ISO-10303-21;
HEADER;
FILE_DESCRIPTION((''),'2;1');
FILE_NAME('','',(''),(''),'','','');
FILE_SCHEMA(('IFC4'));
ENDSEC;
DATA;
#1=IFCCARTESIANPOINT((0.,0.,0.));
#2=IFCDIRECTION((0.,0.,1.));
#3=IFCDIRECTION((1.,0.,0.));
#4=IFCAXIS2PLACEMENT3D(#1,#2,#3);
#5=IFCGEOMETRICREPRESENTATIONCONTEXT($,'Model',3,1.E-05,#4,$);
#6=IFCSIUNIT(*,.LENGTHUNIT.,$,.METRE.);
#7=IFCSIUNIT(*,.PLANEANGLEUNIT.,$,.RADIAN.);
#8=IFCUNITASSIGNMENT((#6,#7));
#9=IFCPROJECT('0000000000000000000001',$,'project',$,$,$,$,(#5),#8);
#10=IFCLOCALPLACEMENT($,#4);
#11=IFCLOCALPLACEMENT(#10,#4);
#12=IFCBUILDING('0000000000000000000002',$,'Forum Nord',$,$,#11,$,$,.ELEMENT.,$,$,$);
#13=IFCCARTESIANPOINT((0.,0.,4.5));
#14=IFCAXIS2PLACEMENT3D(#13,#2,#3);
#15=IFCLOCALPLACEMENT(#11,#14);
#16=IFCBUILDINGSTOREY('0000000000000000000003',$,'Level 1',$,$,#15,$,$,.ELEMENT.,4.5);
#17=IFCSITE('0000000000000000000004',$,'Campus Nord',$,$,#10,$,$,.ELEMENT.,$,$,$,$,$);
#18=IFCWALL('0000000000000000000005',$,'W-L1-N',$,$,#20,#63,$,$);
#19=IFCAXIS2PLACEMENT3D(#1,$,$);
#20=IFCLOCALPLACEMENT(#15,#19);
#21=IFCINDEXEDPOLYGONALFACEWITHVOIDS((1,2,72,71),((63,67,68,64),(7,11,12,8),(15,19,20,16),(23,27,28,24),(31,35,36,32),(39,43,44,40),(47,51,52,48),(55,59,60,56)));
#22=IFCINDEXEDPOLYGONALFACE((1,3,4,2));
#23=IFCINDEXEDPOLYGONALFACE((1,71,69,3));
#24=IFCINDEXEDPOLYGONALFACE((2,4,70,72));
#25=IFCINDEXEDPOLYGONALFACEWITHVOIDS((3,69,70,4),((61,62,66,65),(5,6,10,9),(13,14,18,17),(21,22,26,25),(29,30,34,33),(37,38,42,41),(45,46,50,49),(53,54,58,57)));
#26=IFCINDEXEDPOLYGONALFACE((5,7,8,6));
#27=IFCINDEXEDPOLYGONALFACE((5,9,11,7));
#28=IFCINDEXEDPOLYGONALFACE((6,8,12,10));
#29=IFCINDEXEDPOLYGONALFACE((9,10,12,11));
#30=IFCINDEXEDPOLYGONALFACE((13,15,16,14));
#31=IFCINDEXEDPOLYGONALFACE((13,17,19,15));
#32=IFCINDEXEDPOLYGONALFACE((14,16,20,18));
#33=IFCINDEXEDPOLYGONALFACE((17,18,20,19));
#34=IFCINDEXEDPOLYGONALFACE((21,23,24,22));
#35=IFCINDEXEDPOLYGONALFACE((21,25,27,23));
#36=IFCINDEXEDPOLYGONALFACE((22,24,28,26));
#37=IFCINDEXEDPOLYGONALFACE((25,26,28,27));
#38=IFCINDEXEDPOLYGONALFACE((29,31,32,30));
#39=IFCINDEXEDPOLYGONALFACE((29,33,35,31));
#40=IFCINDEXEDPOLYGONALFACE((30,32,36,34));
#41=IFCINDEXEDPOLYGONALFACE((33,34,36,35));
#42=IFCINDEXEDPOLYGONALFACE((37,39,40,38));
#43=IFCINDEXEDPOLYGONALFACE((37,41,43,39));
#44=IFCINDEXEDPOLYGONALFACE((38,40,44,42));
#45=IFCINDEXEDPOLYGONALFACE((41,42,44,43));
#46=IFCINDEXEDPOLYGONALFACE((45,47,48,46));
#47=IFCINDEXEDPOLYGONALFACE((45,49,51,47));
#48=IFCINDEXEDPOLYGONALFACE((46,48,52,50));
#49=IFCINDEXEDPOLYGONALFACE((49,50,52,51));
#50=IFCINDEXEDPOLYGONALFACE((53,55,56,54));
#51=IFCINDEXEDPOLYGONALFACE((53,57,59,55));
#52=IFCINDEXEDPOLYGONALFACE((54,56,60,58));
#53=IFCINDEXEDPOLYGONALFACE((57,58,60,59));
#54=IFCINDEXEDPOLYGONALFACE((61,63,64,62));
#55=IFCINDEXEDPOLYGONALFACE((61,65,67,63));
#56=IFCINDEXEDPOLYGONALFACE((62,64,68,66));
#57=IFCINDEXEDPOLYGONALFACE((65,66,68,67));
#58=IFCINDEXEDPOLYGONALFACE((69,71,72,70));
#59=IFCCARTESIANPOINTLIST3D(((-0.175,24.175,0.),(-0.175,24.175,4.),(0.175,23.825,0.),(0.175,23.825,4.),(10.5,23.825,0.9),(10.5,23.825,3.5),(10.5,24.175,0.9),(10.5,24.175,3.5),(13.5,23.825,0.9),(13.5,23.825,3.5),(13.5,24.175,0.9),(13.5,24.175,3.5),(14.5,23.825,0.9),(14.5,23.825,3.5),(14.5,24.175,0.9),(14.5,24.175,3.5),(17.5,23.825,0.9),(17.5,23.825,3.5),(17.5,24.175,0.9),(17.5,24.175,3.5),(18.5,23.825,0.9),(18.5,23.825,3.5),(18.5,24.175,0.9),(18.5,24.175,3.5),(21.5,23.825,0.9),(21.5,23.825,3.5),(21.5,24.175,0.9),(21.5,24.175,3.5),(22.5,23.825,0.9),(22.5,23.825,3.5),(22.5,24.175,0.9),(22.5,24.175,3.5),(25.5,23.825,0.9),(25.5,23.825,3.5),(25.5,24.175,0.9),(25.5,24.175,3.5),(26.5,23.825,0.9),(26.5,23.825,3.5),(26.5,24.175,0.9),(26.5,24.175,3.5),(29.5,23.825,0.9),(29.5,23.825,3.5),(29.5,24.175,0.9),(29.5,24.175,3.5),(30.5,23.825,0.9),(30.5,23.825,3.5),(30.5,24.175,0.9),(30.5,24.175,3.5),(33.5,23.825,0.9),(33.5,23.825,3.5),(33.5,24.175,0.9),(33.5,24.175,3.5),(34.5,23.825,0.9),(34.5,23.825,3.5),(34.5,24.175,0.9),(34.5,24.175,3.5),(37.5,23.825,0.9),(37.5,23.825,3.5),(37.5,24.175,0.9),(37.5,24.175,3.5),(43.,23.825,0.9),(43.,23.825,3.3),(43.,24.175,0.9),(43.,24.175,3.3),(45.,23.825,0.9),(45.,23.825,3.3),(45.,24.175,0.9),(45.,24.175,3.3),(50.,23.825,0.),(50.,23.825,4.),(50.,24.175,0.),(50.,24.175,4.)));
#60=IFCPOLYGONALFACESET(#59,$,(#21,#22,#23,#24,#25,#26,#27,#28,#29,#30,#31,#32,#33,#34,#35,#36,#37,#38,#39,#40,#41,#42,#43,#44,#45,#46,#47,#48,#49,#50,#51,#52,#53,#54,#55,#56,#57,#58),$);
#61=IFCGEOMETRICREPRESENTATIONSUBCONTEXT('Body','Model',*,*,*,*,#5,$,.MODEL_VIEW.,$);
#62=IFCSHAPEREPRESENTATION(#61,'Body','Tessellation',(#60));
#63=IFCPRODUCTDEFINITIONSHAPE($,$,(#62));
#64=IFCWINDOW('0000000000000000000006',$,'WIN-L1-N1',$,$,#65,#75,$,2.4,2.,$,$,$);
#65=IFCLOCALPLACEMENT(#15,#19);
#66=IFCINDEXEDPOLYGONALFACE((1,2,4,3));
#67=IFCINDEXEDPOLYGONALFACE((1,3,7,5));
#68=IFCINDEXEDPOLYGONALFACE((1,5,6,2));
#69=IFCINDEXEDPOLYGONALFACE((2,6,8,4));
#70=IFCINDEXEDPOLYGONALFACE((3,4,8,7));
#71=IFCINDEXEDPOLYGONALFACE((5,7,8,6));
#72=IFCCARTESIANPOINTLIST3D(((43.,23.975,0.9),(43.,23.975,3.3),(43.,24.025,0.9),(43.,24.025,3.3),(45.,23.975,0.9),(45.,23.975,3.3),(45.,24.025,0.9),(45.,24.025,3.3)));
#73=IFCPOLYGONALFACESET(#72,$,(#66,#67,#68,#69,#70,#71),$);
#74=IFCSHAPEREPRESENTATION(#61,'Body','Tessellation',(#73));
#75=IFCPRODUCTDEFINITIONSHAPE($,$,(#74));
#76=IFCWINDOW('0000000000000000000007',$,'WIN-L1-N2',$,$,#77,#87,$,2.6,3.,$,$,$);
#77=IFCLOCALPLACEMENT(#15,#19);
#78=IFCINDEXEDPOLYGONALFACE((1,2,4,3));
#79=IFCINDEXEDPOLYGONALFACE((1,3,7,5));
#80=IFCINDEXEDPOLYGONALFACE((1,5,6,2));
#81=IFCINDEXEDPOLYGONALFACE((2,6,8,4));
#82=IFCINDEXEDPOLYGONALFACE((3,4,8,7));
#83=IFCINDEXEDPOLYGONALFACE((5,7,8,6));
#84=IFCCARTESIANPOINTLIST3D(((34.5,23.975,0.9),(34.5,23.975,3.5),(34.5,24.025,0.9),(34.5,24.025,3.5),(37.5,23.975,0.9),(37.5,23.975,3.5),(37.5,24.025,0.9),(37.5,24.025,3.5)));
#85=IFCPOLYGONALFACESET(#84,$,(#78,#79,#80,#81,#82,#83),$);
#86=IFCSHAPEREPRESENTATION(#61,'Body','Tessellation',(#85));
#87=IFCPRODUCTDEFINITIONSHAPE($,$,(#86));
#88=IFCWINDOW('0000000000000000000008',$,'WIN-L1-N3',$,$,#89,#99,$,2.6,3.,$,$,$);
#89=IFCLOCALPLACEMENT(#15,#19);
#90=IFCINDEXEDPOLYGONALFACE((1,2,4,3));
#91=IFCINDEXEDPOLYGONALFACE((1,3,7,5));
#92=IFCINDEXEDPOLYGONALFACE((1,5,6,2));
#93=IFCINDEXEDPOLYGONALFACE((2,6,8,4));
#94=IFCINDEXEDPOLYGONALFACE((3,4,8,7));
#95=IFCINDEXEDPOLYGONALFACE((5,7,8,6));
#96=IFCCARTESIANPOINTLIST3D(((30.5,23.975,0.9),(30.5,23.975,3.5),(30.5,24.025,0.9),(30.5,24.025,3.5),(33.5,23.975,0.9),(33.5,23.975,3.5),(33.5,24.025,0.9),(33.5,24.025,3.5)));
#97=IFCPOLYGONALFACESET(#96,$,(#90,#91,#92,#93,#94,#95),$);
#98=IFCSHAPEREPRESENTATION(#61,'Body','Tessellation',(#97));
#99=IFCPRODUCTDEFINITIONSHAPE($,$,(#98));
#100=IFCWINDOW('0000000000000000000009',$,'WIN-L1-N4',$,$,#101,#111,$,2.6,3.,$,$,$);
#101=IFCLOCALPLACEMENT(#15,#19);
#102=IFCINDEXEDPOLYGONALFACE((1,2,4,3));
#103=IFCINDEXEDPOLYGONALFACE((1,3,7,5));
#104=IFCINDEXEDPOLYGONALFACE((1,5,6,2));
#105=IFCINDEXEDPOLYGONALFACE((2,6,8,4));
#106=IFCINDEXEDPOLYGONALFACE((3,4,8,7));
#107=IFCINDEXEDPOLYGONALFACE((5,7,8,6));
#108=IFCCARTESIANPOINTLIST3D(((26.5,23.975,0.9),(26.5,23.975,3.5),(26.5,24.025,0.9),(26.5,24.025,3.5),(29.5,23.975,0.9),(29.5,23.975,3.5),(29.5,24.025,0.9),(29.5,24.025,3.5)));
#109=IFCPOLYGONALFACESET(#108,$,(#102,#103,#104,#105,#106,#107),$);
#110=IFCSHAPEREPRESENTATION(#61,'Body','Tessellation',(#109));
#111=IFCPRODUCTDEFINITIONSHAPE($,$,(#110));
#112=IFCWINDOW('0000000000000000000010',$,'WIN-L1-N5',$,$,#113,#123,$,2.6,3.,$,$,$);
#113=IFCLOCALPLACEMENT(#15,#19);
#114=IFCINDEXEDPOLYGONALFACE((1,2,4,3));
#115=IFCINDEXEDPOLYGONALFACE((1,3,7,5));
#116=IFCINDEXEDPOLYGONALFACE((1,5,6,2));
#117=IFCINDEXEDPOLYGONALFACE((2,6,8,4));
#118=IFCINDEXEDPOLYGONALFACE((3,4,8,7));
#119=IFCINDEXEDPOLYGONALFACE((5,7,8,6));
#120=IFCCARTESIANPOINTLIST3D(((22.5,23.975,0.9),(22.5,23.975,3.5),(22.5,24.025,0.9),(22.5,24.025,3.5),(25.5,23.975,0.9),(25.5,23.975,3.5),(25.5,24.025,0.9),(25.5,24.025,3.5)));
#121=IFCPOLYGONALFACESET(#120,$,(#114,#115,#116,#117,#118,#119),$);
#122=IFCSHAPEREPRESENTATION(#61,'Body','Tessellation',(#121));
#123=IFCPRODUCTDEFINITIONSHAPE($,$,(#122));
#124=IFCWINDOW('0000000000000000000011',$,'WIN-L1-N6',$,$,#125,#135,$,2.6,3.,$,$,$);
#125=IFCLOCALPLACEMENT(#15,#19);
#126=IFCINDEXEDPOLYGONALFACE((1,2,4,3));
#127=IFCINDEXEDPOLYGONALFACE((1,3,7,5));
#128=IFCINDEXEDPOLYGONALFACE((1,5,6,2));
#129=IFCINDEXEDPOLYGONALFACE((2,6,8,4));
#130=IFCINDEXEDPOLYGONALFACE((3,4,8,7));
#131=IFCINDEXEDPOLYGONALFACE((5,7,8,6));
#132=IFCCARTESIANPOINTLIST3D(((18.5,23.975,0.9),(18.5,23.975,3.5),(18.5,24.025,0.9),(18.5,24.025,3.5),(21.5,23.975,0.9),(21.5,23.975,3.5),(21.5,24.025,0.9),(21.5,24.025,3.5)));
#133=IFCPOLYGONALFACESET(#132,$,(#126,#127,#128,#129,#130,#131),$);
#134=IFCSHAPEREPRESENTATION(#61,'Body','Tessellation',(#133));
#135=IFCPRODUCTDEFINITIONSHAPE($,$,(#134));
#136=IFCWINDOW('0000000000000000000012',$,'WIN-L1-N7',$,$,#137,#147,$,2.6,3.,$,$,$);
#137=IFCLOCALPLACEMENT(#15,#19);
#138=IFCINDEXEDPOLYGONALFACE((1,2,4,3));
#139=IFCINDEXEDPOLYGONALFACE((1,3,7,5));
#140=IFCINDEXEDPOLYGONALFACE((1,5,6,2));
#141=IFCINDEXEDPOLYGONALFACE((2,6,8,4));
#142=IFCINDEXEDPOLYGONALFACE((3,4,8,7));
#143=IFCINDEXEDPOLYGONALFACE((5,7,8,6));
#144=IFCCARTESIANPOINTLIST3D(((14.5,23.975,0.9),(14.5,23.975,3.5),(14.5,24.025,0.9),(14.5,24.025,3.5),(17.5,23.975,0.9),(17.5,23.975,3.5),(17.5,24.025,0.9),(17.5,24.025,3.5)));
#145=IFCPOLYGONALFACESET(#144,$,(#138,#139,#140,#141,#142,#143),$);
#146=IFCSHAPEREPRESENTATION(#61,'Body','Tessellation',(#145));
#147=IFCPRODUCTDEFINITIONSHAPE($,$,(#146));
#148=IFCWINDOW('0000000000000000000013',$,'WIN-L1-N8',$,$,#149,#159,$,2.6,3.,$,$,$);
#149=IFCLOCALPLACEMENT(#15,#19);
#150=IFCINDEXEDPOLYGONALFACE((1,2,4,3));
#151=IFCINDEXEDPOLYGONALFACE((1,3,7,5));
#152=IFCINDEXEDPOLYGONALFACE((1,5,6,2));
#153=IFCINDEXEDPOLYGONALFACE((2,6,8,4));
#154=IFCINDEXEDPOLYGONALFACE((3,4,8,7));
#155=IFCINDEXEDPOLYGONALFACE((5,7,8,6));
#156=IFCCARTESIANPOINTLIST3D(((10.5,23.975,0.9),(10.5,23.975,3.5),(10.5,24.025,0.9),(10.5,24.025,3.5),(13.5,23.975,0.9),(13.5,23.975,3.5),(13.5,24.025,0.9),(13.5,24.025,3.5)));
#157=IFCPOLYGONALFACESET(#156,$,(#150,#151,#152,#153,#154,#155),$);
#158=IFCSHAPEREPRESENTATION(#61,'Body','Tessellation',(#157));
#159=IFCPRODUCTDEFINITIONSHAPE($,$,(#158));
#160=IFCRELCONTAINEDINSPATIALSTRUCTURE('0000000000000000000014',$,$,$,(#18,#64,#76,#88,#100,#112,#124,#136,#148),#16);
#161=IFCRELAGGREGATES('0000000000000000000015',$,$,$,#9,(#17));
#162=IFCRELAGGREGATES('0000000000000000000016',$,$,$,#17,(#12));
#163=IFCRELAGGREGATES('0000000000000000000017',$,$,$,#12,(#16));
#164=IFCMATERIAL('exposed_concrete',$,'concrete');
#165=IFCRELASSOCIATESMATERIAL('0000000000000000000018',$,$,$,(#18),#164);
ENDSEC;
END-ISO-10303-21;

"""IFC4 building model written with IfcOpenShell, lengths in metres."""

from ifc_helpers import new_model, si_unit, frame, frame_2d, origin_with_axes, place, context, subcontext, project, spatial, polyline, rectangle, outline, extrude, material, element, fill, save


model = new_model("IFC4")

# Units and contexts
model_context = context("Model", 3, precision=1e-05, world=origin_with_axes())
body_context = subcontext(model_context, "Body", "Model", "MODEL_VIEW")
ifc_project = project(units=[si_unit("LENGTHUNIT", "METRE"), si_unit("PLANEANGLEUNIT", "RADIAN")], contexts=[model_context])

# Site, building, storey
site_placement = place(None, origin_with_axes())
site = spatial("IfcSite", under=ifc_project, at=site_placement, Name="Campus Nord", CompositionType="ELEMENT")
building_placement = place(site_placement, origin_with_axes())
building = spatial("IfcBuilding", under=site, at=building_placement, Name="Forum Nord", CompositionType="ELEMENT")
storey_placement = place(building_placement, frame((0.0, 0.0, 4.5), z_axis=(0.0, 0.0, 1.0), x_axis=(1.0, 0.0, 0.0)))
storey = spatial("IfcBuildingStorey", under=building, at=storey_placement, Name="Level 1", CompositionType="ELEMENT", Elevation=4.5)

# Wall, openings, windows
ifc_material_1 = material(Name="exposed_concrete", Category="concrete")
wall_1_placement = place(storey_placement, frame((50.0, 24.0, 0.0), z_axis=(0.0, 0.0, 1.0), x_axis=(-1.0, 0.0, 0.0)))
wall_1 = element("IfcWall", 1, at=wall_1_placement, inside=storey, material=ifc_material_1, Name="W-L1-N", context=body_context, shape_type="SweptSolid", body=[
    extrude(outline(polyline([(0.0, -0.175), (50.175, -0.175), (49.825, 0.175), (0.0, 0.175), (0.0, -0.175)])), origin_with_axes(), (0.0, 0.0, 1.0), 4.0),
])
opening_1_placement = place(storey_placement, frame((50.0, 24.0, 0.0), z_axis=(0.0, 0.0, 1.0), x_axis=(-1.0, 0.0, 0.0)))
opening_1 = element("IfcOpeningElement", 2, at=opening_1_placement, cuts=wall_1, context=body_context, shape_type="SweptSolid", body=[
    extrude(rectangle(XDim=2.0, YDim=0.35, at=frame_2d((6.0, 0.0), x_axis=(1.0, 0.0))), frame((0.0, 0.0, 0.9), z_axis=(0.0, 0.0, 1.0), x_axis=(1.0, 0.0, 0.0)), (0.0, 0.0, 1.0), 2.4),
])
opening_2_placement = place(storey_placement, frame((50.0, 24.0, 0.0), z_axis=(0.0, 0.0, 1.0), x_axis=(-1.0, 0.0, 0.0)))
opening_2 = element("IfcOpeningElement", 3, at=opening_2_placement, cuts=wall_1, context=body_context, shape_type="SweptSolid", body=[
    extrude(rectangle(XDim=3.0, YDim=0.35, at=frame_2d((14.0, 0.0), x_axis=(1.0, 0.0))), frame((0.0, 0.0, 0.9), z_axis=(0.0, 0.0, 1.0), x_axis=(1.0, 0.0, 0.0)), (0.0, 0.0, 1.0), 2.6),
])
opening_3_placement = place(storey_placement, frame((50.0, 24.0, 0.0), z_axis=(0.0, 0.0, 1.0), x_axis=(-1.0, 0.0, 0.0)))
opening_3 = element("IfcOpeningElement", 4, at=opening_3_placement, cuts=wall_1, context=body_context, shape_type="SweptSolid", body=[
    extrude(rectangle(XDim=3.0, YDim=0.35, at=frame_2d((18.0, 0.0), x_axis=(1.0, 0.0))), frame((0.0, 0.0, 0.9), z_axis=(0.0, 0.0, 1.0), x_axis=(1.0, 0.0, 0.0)), (0.0, 0.0, 1.0), 2.6),
])
opening_4_placement = place(storey_placement, frame((50.0, 24.0, 0.0), z_axis=(0.0, 0.0, 1.0), x_axis=(-1.0, 0.0, 0.0)))
opening_4 = element("IfcOpeningElement", 5, at=opening_4_placement, cuts=wall_1, context=body_context, shape_type="SweptSolid", body=[
    extrude(rectangle(XDim=3.0, YDim=0.35, at=frame_2d((22.0, 0.0), x_axis=(1.0, 0.0))), frame((0.0, 0.0, 0.9), z_axis=(0.0, 0.0, 1.0), x_axis=(1.0, 0.0, 0.0)), (0.0, 0.0, 1.0), 2.6),
])
opening_5_placement = place(storey_placement, frame((50.0, 24.0, 0.0), z_axis=(0.0, 0.0, 1.0), x_axis=(-1.0, 0.0, 0.0)))
opening_5 = element("IfcOpeningElement", 6, at=opening_5_placement, cuts=wall_1, context=body_context, shape_type="SweptSolid", body=[
    extrude(rectangle(XDim=3.0, YDim=0.35, at=frame_2d((26.0, 0.0), x_axis=(1.0, 0.0))), frame((0.0, 0.0, 0.9), z_axis=(0.0, 0.0, 1.0), x_axis=(1.0, 0.0, 0.0)), (0.0, 0.0, 1.0), 2.6),
])
opening_6_placement = place(storey_placement, frame((50.0, 24.0, 0.0), z_axis=(0.0, 0.0, 1.0), x_axis=(-1.0, 0.0, 0.0)))
opening_6 = element("IfcOpeningElement", 7, at=opening_6_placement, cuts=wall_1, context=body_context, shape_type="SweptSolid", body=[
    extrude(rectangle(XDim=3.0, YDim=0.35, at=frame_2d((30.0, 0.0), x_axis=(1.0, 0.0))), frame((0.0, 0.0, 0.9), z_axis=(0.0, 0.0, 1.0), x_axis=(1.0, 0.0, 0.0)), (0.0, 0.0, 1.0), 2.6),
])
opening_7_placement = place(storey_placement, frame((50.0, 24.0, 0.0), z_axis=(0.0, 0.0, 1.0), x_axis=(-1.0, 0.0, 0.0)))
opening_7 = element("IfcOpeningElement", 8, at=opening_7_placement, cuts=wall_1, context=body_context, shape_type="SweptSolid", body=[
    extrude(rectangle(XDim=3.0, YDim=0.35, at=frame_2d((34.0, 0.0), x_axis=(1.0, 0.0))), frame((0.0, 0.0, 0.9), z_axis=(0.0, 0.0, 1.0), x_axis=(1.0, 0.0, 0.0)), (0.0, 0.0, 1.0), 2.6),
])
opening_8_placement = place(storey_placement, frame((50.0, 24.0, 0.0), z_axis=(0.0, 0.0, 1.0), x_axis=(-1.0, 0.0, 0.0)))
opening_8 = element("IfcOpeningElement", 9, at=opening_8_placement, cuts=wall_1, context=body_context, shape_type="SweptSolid", body=[
    extrude(rectangle(XDim=3.0, YDim=0.35, at=frame_2d((38.0, 0.0), x_axis=(1.0, 0.0))), frame((0.0, 0.0, 0.9), z_axis=(0.0, 0.0, 1.0), x_axis=(1.0, 0.0, 0.0)), (0.0, 0.0, 1.0), 2.6),
])
window_1_placement = place(storey_placement, frame((50.0, 24.0, 0.0), z_axis=(0.0, 0.0, 1.0), x_axis=(-1.0, 0.0, 0.0)))
window_1 = element("IfcWindow", 10, at=window_1_placement, inside=storey, Name="WIN-L1-N1", OverallHeight=2.4, OverallWidth=2.0, context=body_context, shape_type="SweptSolid", body=[
    extrude(rectangle(XDim=2.0, YDim=0.05, at=frame_2d((6.0, 0.0), x_axis=(1.0, 0.0))), frame((0.0, 0.0, 0.9), z_axis=(0.0, 0.0, 1.0), x_axis=(1.0, 0.0, 0.0)), (0.0, 0.0, 1.0), 2.4),
])
fill(opening_1, window_1)
window_2_placement = place(storey_placement, frame((50.0, 24.0, 0.0), z_axis=(0.0, 0.0, 1.0), x_axis=(-1.0, 0.0, 0.0)))
window_2 = element("IfcWindow", 11, at=window_2_placement, inside=storey, Name="WIN-L1-N2", OverallHeight=2.6, OverallWidth=3.0, context=body_context, shape_type="SweptSolid", body=[
    extrude(rectangle(XDim=3.0, YDim=0.05, at=frame_2d((14.0, 0.0), x_axis=(1.0, 0.0))), frame((0.0, 0.0, 0.9), z_axis=(0.0, 0.0, 1.0), x_axis=(1.0, 0.0, 0.0)), (0.0, 0.0, 1.0), 2.6),
])
fill(opening_2, window_2)
window_3_placement = place(storey_placement, frame((50.0, 24.0, 0.0), z_axis=(0.0, 0.0, 1.0), x_axis=(-1.0, 0.0, 0.0)))
window_3 = element("IfcWindow", 12, at=window_3_placement, inside=storey, Name="WIN-L1-N3", OverallHeight=2.6, OverallWidth=3.0, context=body_context, shape_type="SweptSolid", body=[
    extrude(rectangle(XDim=3.0, YDim=0.05, at=frame_2d((18.0, 0.0), x_axis=(1.0, 0.0))), frame((0.0, 0.0, 0.9), z_axis=(0.0, 0.0, 1.0), x_axis=(1.0, 0.0, 0.0)), (0.0, 0.0, 1.0), 2.6),
])
fill(opening_3, window_3)
window_4_placement = place(storey_placement, frame((50.0, 24.0, 0.0), z_axis=(0.0, 0.0, 1.0), x_axis=(-1.0, 0.0, 0.0)))
window_4 = element("IfcWindow", 13, at=window_4_placement, inside=storey, Name="WIN-L1-N4", OverallHeight=2.6, OverallWidth=3.0, context=body_context, shape_type="SweptSolid", body=[
    extrude(rectangle(XDim=3.0, YDim=0.05, at=frame_2d((22.0, 0.0), x_axis=(1.0, 0.0))), frame((0.0, 0.0, 0.9), z_axis=(0.0, 0.0, 1.0), x_axis=(1.0, 0.0, 0.0)), (0.0, 0.0, 1.0), 2.6),
])
fill(opening_4, window_4)
window_5_placement = place(storey_placement, frame((50.0, 24.0, 0.0), z_axis=(0.0, 0.0, 1.0), x_axis=(-1.0, 0.0, 0.0)))
window_5 = element("IfcWindow", 14, at=window_5_placement, inside=storey, Name="WIN-L1-N5", OverallHeight=2.6, OverallWidth=3.0, context=body_context, shape_type="SweptSolid", body=[
    extrude(rectangle(XDim=3.0, YDim=0.05, at=frame_2d((26.0, 0.0), x_axis=(1.0, 0.0))), frame((0.0, 0.0, 0.9), z_axis=(0.0, 0.0, 1.0), x_axis=(1.0, 0.0, 0.0)), (0.0, 0.0, 1.0), 2.6),
])
fill(opening_5, window_5)
window_6_placement = place(storey_placement, frame((50.0, 24.0, 0.0), z_axis=(0.0, 0.0, 1.0), x_axis=(-1.0, 0.0, 0.0)))
window_6 = element("IfcWindow", 15, at=window_6_placement, inside=storey, Name="WIN-L1-N6", OverallHeight=2.6, OverallWidth=3.0, context=body_context, shape_type="SweptSolid", body=[
    extrude(rectangle(XDim=3.0, YDim=0.05, at=frame_2d((30.0, 0.0), x_axis=(1.0, 0.0))), frame((0.0, 0.0, 0.9), z_axis=(0.0, 0.0, 1.0), x_axis=(1.0, 0.0, 0.0)), (0.0, 0.0, 1.0), 2.6),
])
fill(opening_6, window_6)
window_7_placement = place(storey_placement, frame((50.0, 24.0, 0.0), z_axis=(0.0, 0.0, 1.0), x_axis=(-1.0, 0.0, 0.0)))
window_7 = element("IfcWindow", 16, at=window_7_placement, inside=storey, Name="WIN-L1-N7", OverallHeight=2.6, OverallWidth=3.0, context=body_context, shape_type="SweptSolid", body=[
    extrude(rectangle(XDim=3.0, YDim=0.05, at=frame_2d((34.0, 0.0), x_axis=(1.0, 0.0))), frame((0.0, 0.0, 0.9), z_axis=(0.0, 0.0, 1.0), x_axis=(1.0, 0.0, 0.0)), (0.0, 0.0, 1.0), 2.6),
])
fill(opening_7, window_7)
window_8_placement = place(storey_placement, frame((50.0, 24.0, 0.0), z_axis=(0.0, 0.0, 1.0), x_axis=(-1.0, 0.0, 0.0)))
window_8 = element("IfcWindow", 17, at=window_8_placement, inside=storey, Name="WIN-L1-N8", OverallHeight=2.6, OverallWidth=3.0, context=body_context, shape_type="SweptSolid", body=[
    extrude(rectangle(XDim=3.0, YDim=0.05, at=frame_2d((38.0, 0.0), x_axis=(1.0, 0.0))), frame((0.0, 0.0, 0.9), z_axis=(0.0, 0.0, 1.0), x_axis=(1.0, 0.0, 0.0)), (0.0, 0.0, 1.0), 2.6),
])
fill(opening_8, window_8)

save(model, "model.ifc")
